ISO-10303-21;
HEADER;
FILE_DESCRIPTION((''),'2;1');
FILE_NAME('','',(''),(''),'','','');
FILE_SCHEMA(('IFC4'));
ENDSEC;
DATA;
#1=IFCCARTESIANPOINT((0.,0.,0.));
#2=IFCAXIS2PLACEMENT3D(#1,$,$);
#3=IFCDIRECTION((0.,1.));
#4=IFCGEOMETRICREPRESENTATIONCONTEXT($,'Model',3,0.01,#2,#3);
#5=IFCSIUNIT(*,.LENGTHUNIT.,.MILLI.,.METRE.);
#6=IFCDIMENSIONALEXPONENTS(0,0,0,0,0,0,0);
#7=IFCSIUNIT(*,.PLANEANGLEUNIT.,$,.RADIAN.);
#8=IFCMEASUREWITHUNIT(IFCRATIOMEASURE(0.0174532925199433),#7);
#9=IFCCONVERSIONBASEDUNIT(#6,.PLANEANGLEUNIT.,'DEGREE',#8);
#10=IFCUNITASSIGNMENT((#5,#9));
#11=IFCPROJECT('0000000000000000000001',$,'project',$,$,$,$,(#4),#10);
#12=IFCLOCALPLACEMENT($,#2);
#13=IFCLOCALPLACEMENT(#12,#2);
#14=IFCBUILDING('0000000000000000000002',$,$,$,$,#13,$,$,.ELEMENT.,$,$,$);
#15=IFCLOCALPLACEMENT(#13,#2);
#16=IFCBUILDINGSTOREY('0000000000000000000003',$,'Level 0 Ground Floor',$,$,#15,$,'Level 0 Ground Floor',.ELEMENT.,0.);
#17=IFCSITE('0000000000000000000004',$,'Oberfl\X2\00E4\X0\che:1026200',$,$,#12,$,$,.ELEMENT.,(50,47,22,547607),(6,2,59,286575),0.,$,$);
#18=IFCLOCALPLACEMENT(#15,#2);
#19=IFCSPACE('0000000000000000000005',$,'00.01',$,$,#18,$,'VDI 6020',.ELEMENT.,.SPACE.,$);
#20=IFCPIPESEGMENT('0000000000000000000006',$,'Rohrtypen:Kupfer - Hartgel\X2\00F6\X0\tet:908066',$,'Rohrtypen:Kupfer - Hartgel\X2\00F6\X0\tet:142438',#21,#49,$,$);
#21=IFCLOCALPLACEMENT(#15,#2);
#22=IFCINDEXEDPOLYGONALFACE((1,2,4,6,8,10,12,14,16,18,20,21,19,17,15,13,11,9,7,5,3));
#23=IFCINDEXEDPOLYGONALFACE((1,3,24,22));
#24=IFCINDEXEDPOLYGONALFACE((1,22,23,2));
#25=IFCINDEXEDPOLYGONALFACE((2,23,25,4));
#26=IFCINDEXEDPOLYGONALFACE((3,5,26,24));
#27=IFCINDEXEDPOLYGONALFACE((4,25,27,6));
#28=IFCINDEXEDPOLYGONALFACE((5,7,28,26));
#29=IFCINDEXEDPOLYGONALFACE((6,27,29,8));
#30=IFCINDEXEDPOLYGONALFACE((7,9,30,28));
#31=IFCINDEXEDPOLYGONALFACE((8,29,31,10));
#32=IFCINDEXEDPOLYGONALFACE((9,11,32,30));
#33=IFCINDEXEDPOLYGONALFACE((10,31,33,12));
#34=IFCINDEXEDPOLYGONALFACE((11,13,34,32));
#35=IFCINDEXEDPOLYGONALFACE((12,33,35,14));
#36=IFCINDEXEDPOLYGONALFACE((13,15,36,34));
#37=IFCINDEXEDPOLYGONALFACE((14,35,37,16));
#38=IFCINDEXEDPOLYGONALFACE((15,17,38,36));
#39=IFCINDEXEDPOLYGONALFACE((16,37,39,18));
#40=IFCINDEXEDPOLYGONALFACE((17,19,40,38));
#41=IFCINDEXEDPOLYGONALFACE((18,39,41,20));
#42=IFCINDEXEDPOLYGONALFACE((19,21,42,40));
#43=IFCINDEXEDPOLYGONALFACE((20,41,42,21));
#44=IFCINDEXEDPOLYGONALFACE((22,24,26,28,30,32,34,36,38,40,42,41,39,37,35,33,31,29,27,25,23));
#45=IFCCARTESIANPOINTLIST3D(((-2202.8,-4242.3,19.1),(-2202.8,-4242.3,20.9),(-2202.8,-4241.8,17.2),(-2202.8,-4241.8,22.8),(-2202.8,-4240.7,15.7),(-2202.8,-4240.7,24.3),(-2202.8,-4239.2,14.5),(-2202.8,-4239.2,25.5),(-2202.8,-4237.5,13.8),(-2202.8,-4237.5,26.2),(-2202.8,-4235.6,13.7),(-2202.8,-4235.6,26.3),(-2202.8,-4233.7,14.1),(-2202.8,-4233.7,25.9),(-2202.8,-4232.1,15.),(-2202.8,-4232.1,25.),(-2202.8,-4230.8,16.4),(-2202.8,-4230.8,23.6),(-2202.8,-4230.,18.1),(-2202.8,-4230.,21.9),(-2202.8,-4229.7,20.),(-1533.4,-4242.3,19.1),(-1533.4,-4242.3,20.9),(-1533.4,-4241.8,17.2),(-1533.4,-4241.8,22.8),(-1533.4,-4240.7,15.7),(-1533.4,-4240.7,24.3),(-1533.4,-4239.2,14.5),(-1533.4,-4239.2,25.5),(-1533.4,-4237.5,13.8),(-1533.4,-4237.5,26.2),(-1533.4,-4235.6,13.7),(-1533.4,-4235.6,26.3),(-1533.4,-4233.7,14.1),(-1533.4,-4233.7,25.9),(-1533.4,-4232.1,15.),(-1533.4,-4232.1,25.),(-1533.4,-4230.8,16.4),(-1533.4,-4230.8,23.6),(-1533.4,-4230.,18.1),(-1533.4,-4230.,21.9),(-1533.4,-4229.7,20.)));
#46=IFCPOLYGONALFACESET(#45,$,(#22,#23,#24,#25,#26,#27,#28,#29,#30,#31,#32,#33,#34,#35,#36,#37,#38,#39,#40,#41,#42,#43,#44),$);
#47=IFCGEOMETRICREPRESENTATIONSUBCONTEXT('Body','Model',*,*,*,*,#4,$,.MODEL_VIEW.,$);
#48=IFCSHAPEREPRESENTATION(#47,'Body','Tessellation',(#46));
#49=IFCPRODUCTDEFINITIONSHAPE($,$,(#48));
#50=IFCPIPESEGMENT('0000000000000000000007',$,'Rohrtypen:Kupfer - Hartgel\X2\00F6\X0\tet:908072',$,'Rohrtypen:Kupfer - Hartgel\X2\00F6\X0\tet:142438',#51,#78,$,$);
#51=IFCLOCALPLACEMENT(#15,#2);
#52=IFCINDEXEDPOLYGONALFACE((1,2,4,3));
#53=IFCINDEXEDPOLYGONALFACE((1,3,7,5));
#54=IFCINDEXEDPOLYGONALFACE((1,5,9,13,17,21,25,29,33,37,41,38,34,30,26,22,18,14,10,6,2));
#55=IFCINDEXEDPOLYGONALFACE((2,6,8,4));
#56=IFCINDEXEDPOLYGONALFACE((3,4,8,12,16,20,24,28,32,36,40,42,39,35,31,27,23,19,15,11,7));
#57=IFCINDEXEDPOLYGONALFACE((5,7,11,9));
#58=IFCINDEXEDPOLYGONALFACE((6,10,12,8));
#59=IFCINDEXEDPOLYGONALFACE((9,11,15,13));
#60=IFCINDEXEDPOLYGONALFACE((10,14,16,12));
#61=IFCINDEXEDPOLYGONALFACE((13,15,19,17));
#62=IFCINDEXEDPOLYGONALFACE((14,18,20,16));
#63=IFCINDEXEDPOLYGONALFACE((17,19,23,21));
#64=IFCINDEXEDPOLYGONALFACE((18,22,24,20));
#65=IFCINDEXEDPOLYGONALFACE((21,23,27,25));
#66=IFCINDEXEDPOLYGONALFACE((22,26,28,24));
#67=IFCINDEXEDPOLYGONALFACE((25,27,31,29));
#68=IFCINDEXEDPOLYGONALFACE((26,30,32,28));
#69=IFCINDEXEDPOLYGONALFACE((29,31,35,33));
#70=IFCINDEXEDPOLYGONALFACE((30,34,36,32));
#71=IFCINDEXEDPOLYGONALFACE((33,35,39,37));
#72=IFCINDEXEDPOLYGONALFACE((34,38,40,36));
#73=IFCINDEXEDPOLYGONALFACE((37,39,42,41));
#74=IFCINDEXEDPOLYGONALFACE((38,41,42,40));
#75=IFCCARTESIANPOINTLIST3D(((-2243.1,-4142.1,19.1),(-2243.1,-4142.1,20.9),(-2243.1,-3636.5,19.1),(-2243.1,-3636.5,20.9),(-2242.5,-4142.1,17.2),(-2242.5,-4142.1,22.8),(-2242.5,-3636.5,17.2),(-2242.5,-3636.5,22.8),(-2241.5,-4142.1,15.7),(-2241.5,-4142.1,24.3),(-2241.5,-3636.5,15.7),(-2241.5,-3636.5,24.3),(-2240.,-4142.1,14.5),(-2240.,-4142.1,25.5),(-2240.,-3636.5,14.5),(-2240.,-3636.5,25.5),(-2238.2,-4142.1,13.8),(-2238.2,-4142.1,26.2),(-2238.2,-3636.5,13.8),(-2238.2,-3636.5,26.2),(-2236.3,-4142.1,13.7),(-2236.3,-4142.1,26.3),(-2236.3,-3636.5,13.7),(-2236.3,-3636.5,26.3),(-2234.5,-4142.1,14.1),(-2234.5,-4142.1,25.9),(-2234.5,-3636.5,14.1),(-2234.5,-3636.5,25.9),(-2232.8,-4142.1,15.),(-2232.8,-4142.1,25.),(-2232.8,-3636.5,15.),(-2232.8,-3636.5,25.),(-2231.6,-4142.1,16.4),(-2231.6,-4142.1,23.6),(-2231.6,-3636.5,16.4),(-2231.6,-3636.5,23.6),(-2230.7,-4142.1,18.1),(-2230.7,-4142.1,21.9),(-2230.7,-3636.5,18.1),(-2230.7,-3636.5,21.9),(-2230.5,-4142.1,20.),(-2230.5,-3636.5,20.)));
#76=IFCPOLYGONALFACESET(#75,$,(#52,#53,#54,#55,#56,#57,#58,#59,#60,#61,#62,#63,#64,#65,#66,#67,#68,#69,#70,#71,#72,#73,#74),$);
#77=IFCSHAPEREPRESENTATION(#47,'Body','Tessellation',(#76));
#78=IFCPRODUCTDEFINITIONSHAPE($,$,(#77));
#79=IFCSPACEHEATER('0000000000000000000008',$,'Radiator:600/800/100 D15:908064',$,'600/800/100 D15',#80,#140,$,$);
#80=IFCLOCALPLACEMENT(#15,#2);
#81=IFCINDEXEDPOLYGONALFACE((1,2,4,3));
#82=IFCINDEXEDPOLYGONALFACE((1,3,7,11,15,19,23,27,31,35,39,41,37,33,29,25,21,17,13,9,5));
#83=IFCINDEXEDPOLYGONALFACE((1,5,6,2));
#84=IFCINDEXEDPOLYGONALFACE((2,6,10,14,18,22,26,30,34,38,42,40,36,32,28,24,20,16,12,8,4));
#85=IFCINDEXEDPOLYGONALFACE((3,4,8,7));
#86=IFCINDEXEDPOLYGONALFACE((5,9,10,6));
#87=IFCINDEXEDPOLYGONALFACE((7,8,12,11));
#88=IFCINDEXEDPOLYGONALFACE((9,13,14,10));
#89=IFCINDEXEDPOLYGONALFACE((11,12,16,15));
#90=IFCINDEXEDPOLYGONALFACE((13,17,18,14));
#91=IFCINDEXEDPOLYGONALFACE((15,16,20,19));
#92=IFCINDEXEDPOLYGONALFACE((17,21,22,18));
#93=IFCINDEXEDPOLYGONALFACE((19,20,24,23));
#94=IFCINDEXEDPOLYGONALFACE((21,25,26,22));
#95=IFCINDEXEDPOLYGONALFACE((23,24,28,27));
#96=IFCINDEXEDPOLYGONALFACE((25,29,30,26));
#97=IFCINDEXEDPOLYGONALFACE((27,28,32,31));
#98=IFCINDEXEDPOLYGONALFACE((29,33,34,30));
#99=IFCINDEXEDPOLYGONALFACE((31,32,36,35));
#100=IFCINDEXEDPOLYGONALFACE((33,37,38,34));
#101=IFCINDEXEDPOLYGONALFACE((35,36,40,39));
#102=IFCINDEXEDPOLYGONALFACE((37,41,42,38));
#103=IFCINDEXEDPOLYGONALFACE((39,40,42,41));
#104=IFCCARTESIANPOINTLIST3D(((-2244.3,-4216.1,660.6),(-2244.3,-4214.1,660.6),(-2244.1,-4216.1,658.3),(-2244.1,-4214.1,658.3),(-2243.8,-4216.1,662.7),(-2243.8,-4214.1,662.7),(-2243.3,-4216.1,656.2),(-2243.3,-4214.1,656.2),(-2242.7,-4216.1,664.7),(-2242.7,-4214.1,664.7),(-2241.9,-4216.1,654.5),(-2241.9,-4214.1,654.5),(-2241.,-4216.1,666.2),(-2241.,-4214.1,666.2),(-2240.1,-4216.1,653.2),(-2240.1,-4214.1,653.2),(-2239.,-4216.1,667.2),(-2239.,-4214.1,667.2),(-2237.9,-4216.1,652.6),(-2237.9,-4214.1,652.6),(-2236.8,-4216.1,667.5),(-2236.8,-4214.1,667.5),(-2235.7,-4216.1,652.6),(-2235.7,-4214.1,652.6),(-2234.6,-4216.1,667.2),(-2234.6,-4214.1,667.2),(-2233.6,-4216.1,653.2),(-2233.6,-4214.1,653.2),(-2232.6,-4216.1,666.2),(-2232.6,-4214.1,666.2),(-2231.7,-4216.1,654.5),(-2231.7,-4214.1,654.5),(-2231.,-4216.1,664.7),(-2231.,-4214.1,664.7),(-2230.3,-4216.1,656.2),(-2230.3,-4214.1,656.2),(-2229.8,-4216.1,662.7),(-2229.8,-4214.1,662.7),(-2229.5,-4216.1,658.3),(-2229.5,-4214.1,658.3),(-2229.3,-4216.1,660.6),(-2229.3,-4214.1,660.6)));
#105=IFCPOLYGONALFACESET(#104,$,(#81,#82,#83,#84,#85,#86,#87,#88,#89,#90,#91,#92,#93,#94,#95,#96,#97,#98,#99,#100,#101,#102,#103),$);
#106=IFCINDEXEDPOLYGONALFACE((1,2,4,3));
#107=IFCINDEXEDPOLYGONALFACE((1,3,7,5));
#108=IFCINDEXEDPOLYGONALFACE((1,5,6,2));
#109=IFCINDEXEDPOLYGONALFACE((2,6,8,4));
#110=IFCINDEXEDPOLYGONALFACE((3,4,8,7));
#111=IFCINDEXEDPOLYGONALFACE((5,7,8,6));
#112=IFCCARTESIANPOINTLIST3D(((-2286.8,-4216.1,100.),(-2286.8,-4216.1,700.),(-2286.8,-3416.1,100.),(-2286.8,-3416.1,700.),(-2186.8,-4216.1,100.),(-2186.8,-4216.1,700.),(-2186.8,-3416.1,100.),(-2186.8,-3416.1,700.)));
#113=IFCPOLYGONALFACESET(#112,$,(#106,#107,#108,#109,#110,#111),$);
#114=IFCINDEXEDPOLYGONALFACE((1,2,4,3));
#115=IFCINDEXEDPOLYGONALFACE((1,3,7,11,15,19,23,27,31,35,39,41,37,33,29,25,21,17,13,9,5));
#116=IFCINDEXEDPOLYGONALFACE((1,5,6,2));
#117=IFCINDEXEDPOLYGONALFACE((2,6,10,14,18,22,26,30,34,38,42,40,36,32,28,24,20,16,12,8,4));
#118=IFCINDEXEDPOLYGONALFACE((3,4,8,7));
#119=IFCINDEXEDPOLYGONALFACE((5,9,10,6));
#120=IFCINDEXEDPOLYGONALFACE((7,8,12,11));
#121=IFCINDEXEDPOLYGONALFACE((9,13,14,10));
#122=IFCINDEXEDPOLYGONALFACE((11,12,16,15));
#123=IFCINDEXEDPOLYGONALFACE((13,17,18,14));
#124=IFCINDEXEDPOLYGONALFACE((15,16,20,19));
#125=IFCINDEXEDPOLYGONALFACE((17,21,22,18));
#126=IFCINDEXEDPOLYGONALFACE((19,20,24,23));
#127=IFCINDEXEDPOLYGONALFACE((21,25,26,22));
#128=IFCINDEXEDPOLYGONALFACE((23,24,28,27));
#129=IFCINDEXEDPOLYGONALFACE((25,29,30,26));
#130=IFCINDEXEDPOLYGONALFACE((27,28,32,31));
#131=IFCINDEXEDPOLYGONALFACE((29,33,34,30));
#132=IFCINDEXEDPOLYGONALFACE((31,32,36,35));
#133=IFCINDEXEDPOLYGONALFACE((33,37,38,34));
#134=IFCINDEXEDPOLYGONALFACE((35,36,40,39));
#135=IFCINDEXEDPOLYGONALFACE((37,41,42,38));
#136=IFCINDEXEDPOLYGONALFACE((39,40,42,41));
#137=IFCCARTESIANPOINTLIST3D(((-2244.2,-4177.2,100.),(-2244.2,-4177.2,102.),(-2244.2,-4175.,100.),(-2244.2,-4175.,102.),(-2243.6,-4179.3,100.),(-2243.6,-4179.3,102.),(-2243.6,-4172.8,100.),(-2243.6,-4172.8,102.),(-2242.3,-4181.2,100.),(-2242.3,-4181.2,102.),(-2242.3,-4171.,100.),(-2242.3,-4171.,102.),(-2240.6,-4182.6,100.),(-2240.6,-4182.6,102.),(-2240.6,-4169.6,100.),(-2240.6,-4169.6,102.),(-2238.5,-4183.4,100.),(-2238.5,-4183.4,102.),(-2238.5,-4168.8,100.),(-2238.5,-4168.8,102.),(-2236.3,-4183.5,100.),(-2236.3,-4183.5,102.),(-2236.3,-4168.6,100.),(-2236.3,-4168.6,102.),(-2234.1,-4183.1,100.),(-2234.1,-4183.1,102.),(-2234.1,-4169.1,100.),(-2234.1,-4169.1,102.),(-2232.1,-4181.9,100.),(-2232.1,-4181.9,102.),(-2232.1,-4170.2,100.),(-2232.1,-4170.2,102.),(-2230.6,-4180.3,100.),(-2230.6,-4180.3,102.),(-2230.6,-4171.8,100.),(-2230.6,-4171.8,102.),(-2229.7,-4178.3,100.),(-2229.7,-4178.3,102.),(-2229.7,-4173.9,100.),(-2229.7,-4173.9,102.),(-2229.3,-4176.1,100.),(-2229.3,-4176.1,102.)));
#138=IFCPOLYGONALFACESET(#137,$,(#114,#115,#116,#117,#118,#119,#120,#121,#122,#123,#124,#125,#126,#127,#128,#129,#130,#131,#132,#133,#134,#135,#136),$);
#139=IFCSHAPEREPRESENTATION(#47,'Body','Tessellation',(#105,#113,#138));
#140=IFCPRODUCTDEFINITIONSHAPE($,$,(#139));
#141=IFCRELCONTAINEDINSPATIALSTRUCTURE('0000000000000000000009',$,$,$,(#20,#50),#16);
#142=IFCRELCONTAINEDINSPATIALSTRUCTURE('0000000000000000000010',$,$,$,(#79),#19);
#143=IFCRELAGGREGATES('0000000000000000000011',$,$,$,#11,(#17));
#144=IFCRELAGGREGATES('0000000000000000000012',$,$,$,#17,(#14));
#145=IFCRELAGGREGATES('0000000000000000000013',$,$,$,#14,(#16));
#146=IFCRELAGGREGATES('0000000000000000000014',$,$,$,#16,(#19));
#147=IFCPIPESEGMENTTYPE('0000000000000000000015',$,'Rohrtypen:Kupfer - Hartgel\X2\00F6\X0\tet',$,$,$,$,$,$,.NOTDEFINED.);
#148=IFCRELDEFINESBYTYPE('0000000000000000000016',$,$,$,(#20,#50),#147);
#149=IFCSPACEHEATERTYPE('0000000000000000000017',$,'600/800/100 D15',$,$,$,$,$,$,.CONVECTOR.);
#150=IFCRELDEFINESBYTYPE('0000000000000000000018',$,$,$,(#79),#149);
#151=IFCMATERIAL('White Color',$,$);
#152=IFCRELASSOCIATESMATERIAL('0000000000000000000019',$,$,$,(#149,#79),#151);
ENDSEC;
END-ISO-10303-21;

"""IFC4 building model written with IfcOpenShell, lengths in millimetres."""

from ifc_helpers import new_model, entity, si_unit, converted_unit, direction, frame, frame_2d, origin, place, context, subcontext, project, spatial, rectangle, circle, extrude, source, transform, mapped, material, type_object, type_shapes, element, save


model = new_model("IFC4")

# Units and contexts
model_context = context("Model", 3, precision=0.01, world=origin(), true_north=direction((0.0, 1.0)))
body_context = subcontext(model_context, "Body", "Model", "MODEL_VIEW")
ifc_project = project(units=[si_unit("LENGTHUNIT", "METRE", prefix="MILLI"), converted_unit("PLANEANGLEUNIT", "DEGREE", entity("IfcRatioMeasure", 0.0174532925199433), si_unit("PLANEANGLEUNIT", "RADIAN"), dimensions=[0, 0, 0, 0, 0, 0, 0])], contexts=[model_context])

# Site, building, storey
site_placement = place(None, origin())
site = spatial("IfcSite", under=ifc_project, at=site_placement, Name="Oberfläche:1026200", CompositionType="ELEMENT", RefLatitude=(50, 47, 22, 547607), RefLongitude=(6, 2, 59, 286575), RefElevation=0.0)
building_placement = place(site_placement, origin())
building = spatial("IfcBuilding", under=site, at=building_placement, CompositionType="ELEMENT")
storey_placement = place(building_placement, origin())
storey = spatial("IfcBuildingStorey", under=building, at=storey_placement, Name="Level 0 Ground Floor", LongName="Level 0 Ground Floor", CompositionType="ELEMENT", Elevation=0.0)

# Pipe segments
pipe_segment_type = type_object("IfcPipeSegmentType", Name="Rohrtypen:Kupfer - Hartgelötet", PredefinedType="NOTDEFINED")
pipe_segment_1_placement = place(storey_placement, frame((-2202.8, -4244.0, 12.1)))
element("IfcPipeSegment", 1, at=pipe_segment_1_placement, inside=storey, type_object=pipe_segment_type, Name="Rohrtypen:Kupfer - Hartgelötet:908066", ObjectType="Rohrtypen:Kupfer - Hartgelötet:142438", context=body_context, shape_type="SweptSolid", body=[
    extrude(circle(Radius=6.3, at=frame_2d((0.0, 0.0), x_axis=(1.0, 0.0))), frame((0.0, 7.9, 7.9), z_axis=(1.0, 0.000044, 0.0), x_axis=(-0.000044, 1.0, 0.0)), (0.0, 0.0, 1.0), 669.4),
])
pipe_segment_2_placement = place(storey_placement, frame((-2244.8, -4142.1, 12.1)))
element("IfcPipeSegment", 2, at=pipe_segment_2_placement, inside=storey, type_object=pipe_segment_type, Name="Rohrtypen:Kupfer - Hartgelötet:908072", ObjectType="Rohrtypen:Kupfer - Hartgelötet:142438", context=body_context, shape_type="SweptSolid", body=[
    extrude(circle(Radius=6.3, at=frame_2d((0.0, 0.0), x_axis=(1.0, 0.0))), frame((7.9, 0.0, 7.9), z_axis=(0.0, 1.0, 0.0), x_axis=(1.0, 0.0, 0.0)), (0.0, 0.0, 1.0), 505.5),
])

# Shared definitions
space_placement = place(storey_placement, origin())
space = spatial("IfcSpace", under=storey, at=space_placement, Name="00.01", LongName="VDI 6020", CompositionType="ELEMENT", PredefinedType="SPACE")

# Space heater
ifc_material_1 = material(Name="White Color")
space_heater_type = type_object("IfcSpaceHeaterType", Name="600/800/100 D15", PredefinedType="CONVECTOR", material=ifc_material_1)
shared_shape_1 = source(origin(), body_context, "Body", "SweptSolid", [
    extrude(circle(Radius=7.5, at=frame_2d((0.0, 0.0), x_axis=(1.0, 0.0))), frame((798.0, 50.0, 560.0), z_axis=(1.0, 0.0, 0.0), x_axis=(0.0, 0.0, 1.0)), (0.0, 0.0, 1.0), 2.0),
    extrude(rectangle(XDim=100.0, YDim=800.0, at=frame_2d((0.0, 0.0), x_axis=(1.0, 0.0))), frame((400.0, 50.0, 0.0), z_axis=(0.0, 0.0, 1.0), x_axis=(0.0, 1.0, 0.0)), (0.0, 0.0, 1.0), 600.0),
    extrude(circle(Radius=7.5, at=frame_2d((0.0, 0.0), x_axis=(1.0, 0.0))), frame((760.0, 50.0, 0.0), z_axis=(0.0, 0.0, 1.0), x_axis=(0.0, 1.0, 0.0)), (0.0, 0.0, 1.0), 2.0),
])
type_shapes(space_heater_type, [shared_shape_1])
space_heater_placement = place(space_placement, frame((-2286.8, -3416.1, 100.0), z_axis=(0.0, 0.0, 1.0), x_axis=(0.0, -1.0, 0.0)))
element("IfcSpaceHeater", 3, at=space_heater_placement, inside=space, type_object=space_heater_type, material=ifc_material_1, Name="Radiator:600/800/100 D15:908064", ObjectType="600/800/100 D15", context=body_context, shape_type="MappedRepresentation", body=[
    mapped(shared_shape_1, transform((0.0, 0.0, 0.0), scale=1.0)),
])

save(model, "model.ifc")
